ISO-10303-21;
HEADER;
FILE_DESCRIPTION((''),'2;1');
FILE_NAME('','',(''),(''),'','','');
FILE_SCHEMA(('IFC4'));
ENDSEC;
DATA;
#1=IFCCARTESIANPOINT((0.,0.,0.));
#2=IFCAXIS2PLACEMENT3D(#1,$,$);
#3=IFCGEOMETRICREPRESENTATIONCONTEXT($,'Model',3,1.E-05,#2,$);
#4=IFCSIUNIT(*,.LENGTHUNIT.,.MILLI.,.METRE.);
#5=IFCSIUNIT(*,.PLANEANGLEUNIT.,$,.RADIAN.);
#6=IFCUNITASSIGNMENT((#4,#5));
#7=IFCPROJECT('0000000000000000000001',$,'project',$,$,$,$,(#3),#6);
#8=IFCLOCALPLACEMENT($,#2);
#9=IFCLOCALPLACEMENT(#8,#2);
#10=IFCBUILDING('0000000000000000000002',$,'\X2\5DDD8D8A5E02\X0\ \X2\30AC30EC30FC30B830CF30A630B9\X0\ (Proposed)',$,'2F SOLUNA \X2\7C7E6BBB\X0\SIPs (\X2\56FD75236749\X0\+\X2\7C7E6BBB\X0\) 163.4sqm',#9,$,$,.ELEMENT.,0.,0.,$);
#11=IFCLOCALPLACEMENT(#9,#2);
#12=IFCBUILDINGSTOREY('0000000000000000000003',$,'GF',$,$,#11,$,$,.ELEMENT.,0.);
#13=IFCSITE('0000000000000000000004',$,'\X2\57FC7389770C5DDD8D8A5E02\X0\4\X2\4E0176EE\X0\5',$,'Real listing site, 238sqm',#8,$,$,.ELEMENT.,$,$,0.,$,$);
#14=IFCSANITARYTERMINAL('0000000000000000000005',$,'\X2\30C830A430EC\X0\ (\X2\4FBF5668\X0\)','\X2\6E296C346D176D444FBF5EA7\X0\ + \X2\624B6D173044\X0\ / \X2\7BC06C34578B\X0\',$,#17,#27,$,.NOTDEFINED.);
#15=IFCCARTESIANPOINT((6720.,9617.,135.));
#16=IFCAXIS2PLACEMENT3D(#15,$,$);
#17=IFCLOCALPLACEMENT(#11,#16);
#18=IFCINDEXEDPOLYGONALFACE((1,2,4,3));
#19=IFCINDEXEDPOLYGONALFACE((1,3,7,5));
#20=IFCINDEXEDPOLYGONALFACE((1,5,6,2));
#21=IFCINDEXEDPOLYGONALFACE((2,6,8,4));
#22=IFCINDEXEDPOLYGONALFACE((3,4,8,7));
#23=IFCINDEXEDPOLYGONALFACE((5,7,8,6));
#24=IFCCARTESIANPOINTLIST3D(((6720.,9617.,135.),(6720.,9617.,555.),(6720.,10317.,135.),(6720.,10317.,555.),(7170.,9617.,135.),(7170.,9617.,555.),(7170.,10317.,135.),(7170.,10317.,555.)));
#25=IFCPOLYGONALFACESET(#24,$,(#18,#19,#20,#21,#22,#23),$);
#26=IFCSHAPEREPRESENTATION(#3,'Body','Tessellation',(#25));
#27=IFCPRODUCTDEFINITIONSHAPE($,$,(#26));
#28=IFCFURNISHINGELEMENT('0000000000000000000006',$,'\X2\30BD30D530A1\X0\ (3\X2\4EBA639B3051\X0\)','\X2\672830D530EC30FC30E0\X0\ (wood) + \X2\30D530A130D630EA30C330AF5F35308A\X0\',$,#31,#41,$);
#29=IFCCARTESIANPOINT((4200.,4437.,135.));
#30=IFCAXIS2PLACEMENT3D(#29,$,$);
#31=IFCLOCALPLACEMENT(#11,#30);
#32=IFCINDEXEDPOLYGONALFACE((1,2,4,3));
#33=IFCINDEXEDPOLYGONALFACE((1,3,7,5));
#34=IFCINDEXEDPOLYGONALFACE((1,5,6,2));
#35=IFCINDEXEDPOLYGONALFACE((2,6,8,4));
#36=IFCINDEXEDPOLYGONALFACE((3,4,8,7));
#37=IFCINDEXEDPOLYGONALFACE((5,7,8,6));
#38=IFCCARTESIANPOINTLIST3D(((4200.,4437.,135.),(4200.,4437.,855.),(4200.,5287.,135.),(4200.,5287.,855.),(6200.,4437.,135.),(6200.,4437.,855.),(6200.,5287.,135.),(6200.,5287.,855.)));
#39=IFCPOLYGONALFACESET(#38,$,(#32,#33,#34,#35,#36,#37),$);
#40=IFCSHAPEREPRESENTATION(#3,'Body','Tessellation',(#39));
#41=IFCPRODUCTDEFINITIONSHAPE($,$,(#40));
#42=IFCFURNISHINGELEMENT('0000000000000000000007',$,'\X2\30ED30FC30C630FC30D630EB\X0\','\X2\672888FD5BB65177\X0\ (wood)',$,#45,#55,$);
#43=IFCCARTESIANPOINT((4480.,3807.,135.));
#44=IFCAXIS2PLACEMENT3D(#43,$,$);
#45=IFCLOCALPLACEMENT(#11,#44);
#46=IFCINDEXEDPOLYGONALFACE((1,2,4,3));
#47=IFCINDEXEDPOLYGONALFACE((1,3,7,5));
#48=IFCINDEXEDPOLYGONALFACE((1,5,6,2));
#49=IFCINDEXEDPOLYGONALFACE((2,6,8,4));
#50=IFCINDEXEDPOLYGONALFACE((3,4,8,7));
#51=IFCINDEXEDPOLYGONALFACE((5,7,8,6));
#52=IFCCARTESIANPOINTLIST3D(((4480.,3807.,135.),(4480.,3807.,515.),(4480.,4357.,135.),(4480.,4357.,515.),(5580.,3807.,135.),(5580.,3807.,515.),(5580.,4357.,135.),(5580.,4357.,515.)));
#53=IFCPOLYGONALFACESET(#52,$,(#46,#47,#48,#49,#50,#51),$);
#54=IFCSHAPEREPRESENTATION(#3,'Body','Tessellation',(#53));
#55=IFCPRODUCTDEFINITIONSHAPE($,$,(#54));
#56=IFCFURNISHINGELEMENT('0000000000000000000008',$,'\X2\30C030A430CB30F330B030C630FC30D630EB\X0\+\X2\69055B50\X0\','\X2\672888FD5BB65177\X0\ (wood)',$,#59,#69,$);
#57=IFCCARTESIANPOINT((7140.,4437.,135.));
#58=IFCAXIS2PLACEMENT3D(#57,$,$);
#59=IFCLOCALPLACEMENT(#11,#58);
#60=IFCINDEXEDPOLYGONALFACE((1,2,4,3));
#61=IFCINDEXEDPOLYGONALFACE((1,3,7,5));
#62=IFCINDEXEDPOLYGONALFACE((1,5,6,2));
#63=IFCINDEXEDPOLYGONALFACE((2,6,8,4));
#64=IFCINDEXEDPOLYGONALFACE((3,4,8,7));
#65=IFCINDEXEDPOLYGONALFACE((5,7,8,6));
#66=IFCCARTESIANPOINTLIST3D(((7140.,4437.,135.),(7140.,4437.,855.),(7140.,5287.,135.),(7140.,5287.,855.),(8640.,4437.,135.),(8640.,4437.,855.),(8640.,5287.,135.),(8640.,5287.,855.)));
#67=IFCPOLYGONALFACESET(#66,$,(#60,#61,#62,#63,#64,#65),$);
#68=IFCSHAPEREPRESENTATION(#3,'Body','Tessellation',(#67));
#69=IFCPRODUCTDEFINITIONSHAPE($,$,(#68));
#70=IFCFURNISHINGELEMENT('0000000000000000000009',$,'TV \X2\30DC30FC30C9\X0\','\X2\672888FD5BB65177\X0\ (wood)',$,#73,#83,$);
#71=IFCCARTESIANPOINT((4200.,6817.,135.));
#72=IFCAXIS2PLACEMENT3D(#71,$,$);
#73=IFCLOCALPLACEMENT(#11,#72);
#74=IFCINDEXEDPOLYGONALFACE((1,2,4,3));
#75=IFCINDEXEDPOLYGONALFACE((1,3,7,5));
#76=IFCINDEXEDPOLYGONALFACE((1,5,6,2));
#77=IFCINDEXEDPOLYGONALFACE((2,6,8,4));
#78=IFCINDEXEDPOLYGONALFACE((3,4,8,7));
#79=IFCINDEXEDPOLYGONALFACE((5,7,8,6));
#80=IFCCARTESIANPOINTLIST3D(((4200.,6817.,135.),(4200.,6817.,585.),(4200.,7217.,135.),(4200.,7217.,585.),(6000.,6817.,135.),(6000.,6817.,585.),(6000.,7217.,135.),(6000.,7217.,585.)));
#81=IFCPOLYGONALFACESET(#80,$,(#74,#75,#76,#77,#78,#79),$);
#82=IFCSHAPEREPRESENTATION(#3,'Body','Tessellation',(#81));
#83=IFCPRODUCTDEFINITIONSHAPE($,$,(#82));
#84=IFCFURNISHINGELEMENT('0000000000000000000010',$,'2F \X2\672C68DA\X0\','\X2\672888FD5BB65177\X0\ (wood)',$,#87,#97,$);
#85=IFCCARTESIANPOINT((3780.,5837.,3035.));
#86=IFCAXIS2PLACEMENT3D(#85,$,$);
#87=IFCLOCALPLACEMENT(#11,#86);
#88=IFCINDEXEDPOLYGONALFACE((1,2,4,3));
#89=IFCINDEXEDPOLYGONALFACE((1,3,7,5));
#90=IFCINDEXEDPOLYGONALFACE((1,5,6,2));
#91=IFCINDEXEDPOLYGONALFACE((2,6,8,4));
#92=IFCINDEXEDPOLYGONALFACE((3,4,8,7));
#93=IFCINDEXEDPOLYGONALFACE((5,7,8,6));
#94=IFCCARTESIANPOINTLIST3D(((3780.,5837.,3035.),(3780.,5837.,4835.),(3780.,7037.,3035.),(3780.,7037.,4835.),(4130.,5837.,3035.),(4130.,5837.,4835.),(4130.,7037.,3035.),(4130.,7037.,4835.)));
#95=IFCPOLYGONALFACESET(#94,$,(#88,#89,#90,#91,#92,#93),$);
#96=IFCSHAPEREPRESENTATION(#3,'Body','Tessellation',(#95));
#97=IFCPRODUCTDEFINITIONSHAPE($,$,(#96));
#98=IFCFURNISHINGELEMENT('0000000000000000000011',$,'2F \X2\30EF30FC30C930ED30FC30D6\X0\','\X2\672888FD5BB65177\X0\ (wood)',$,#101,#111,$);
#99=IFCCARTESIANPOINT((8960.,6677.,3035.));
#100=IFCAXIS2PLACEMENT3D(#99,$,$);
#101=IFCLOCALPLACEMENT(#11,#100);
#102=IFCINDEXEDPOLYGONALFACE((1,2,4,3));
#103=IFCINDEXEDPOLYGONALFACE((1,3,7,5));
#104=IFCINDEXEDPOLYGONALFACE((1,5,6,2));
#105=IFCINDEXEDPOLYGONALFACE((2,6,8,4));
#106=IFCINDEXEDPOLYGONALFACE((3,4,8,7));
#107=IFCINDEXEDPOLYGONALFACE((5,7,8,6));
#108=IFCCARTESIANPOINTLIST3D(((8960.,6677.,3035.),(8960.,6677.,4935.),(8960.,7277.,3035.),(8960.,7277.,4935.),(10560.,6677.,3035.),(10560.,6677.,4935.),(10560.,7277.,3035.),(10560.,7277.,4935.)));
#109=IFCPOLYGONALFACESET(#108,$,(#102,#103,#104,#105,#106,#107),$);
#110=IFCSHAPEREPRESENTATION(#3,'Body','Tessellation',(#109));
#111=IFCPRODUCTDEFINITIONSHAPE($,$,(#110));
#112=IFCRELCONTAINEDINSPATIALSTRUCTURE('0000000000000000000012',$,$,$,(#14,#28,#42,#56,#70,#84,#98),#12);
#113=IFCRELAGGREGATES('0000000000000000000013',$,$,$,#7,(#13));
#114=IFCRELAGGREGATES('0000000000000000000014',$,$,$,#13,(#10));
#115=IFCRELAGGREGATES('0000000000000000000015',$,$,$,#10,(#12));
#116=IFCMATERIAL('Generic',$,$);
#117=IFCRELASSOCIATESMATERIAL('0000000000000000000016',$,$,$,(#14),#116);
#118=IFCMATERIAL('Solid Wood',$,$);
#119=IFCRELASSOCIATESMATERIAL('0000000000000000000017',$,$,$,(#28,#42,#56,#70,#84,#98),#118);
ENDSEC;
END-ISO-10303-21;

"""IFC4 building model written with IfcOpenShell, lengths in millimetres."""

from ifc_helpers import new_model, si_unit, frame, frame_2d, origin, place, context, project, spatial, rectangle, extrude, material, element, save


model = new_model("IFC4")

# Units and contexts
model_context = context("Model", 3, precision=1e-05, world=origin())
ifc_project = project(units=[si_unit("LENGTHUNIT", "METRE", prefix="MILLI"), si_unit("PLANEANGLEUNIT", "RADIAN")], contexts=[model_context])

# Site, building, storey
site_placement = place(None, origin())
site = spatial("IfcSite", under=ifc_project, at=site_placement, Name="埼玉県川越市4丁目5", ObjectType="Real listing site, 238sqm", CompositionType="ELEMENT", RefElevation=0.0)
building_placement = place(site_placement, origin())
building = spatial("IfcBuilding", under=site, at=building_placement, Name="川越市 ガレージハウス (Proposed)", ObjectType="2F SOLUNA 籾殻SIPs (国産杉+籾殻) 163.4sqm", CompositionType="ELEMENT", ElevationOfRefHeight=0.0, ElevationOfTerrain=0.0)
storey_placement = place(building_placement, origin())
storey = spatial("IfcBuildingStorey", under=building, at=storey_placement, Name="GF", CompositionType="ELEMENT", Elevation=0.0)

# Shared definitions
ifc_material_1 = material(Name="Generic")

# Shared definitions
ifc_material_2 = material(Name="Solid Wood")

# Sanitary terminal
sanitary_terminal_1_placement = place(storey_placement, frame((6720.0, 9617.0, 135.0)))
element("IfcSanitaryTerminal", 1, at=sanitary_terminal_1_placement, inside=storey, material=ifc_material_1, Name="トイレ (便器)", Description="温水洗浄便座 + 手洗い / 節水型", PredefinedType="NOTDEFINED", context=model_context, shape_type="SweptSolid", body=[
    extrude(rectangle(XDim=450.0, YDim=700.0, at=frame_2d((225.0, 350.0))), frame((6720.0, 9617.0, 135.0)), (0.0, 0.0, 1.0), 420.0),
])

# Furnishing elements
furnishing_1_placement = place(storey_placement, frame((4200.0, 4437.0, 135.0)))
element("IfcFurnishingElement", 2, at=furnishing_1_placement, inside=storey, material=ifc_material_2, Name="ソファ (3人掛け)", Description="木フレーム (wood) + ファブリック張り", context=model_context, shape_type="SweptSolid", body=[
    extrude(rectangle(XDim=2000.0, YDim=850.0, at=frame_2d((1000.0, 425.0))), frame((4200.0, 4437.0, 135.0)), (0.0, 0.0, 1.0), 720.0),
])
furnishing_2_placement = place(storey_placement, frame((4480.0, 3807.0, 135.0)))
element("IfcFurnishingElement", 3, at=furnishing_2_placement, inside=storey, material=ifc_material_2, Name="ローテーブル", Description="木製家具 (wood)", context=model_context, shape_type="SweptSolid", body=[
    extrude(rectangle(XDim=1100.0, YDim=550.0, at=frame_2d((550.0, 275.0))), frame((4480.0, 3807.0, 135.0)), (0.0, 0.0, 1.0), 380.0),
])
furnishing_3_placement = place(storey_placement, frame((7140.0, 4437.0, 135.0)))
element("IfcFurnishingElement", 4, at=furnishing_3_placement, inside=storey, material=ifc_material_2, Name="ダイニングテーブル+椅子", Description="木製家具 (wood)", context=model_context, shape_type="SweptSolid", body=[
    extrude(rectangle(XDim=1500.0, YDim=850.0, at=frame_2d((750.0, 425.0))), frame((7140.0, 4437.0, 135.0)), (0.0, 0.0, 1.0), 720.0),
])
furnishing_4_placement = place(storey_placement, frame((4200.0, 6817.0, 135.0)))
element("IfcFurnishingElement", 5, at=furnishing_4_placement, inside=storey, material=ifc_material_2, Name="TV ボード", Description="木製家具 (wood)", context=model_context, shape_type="SweptSolid", body=[
    extrude(rectangle(XDim=1800.0, YDim=400.0, at=frame_2d((900.0, 200.0))), frame((4200.0, 6817.0, 135.0)), (0.0, 0.0, 1.0), 450.0),
])
furnishing_5_placement = place(storey_placement, frame((3780.0, 5837.0, 3035.0)))
element("IfcFurnishingElement", 6, at=furnishing_5_placement, inside=storey, material=ifc_material_2, Name="2F 本棚", Description="木製家具 (wood)", context=model_context, shape_type="SweptSolid", body=[
    extrude(rectangle(XDim=350.0, YDim=1200.0, at=frame_2d((175.0, 600.0))), frame((3780.0, 5837.0, 3035.0)), (0.0, 0.0, 1.0), 1800.0),
])
furnishing_6_placement = place(storey_placement, frame((8960.0, 6677.0, 3035.0)))
element("IfcFurnishingElement", 7, at=furnishing_6_placement, inside=storey, material=ifc_material_2, Name="2F ワードローブ", Description="木製家具 (wood)", context=model_context, shape_type="SweptSolid", body=[
    extrude(rectangle(XDim=1600.0, YDim=600.0, at=frame_2d((800.0, 300.0))), frame((8960.0, 6677.0, 3035.0)), (0.0, 0.0, 1.0), 1900.0),
])

save(model, "model.ifc")
